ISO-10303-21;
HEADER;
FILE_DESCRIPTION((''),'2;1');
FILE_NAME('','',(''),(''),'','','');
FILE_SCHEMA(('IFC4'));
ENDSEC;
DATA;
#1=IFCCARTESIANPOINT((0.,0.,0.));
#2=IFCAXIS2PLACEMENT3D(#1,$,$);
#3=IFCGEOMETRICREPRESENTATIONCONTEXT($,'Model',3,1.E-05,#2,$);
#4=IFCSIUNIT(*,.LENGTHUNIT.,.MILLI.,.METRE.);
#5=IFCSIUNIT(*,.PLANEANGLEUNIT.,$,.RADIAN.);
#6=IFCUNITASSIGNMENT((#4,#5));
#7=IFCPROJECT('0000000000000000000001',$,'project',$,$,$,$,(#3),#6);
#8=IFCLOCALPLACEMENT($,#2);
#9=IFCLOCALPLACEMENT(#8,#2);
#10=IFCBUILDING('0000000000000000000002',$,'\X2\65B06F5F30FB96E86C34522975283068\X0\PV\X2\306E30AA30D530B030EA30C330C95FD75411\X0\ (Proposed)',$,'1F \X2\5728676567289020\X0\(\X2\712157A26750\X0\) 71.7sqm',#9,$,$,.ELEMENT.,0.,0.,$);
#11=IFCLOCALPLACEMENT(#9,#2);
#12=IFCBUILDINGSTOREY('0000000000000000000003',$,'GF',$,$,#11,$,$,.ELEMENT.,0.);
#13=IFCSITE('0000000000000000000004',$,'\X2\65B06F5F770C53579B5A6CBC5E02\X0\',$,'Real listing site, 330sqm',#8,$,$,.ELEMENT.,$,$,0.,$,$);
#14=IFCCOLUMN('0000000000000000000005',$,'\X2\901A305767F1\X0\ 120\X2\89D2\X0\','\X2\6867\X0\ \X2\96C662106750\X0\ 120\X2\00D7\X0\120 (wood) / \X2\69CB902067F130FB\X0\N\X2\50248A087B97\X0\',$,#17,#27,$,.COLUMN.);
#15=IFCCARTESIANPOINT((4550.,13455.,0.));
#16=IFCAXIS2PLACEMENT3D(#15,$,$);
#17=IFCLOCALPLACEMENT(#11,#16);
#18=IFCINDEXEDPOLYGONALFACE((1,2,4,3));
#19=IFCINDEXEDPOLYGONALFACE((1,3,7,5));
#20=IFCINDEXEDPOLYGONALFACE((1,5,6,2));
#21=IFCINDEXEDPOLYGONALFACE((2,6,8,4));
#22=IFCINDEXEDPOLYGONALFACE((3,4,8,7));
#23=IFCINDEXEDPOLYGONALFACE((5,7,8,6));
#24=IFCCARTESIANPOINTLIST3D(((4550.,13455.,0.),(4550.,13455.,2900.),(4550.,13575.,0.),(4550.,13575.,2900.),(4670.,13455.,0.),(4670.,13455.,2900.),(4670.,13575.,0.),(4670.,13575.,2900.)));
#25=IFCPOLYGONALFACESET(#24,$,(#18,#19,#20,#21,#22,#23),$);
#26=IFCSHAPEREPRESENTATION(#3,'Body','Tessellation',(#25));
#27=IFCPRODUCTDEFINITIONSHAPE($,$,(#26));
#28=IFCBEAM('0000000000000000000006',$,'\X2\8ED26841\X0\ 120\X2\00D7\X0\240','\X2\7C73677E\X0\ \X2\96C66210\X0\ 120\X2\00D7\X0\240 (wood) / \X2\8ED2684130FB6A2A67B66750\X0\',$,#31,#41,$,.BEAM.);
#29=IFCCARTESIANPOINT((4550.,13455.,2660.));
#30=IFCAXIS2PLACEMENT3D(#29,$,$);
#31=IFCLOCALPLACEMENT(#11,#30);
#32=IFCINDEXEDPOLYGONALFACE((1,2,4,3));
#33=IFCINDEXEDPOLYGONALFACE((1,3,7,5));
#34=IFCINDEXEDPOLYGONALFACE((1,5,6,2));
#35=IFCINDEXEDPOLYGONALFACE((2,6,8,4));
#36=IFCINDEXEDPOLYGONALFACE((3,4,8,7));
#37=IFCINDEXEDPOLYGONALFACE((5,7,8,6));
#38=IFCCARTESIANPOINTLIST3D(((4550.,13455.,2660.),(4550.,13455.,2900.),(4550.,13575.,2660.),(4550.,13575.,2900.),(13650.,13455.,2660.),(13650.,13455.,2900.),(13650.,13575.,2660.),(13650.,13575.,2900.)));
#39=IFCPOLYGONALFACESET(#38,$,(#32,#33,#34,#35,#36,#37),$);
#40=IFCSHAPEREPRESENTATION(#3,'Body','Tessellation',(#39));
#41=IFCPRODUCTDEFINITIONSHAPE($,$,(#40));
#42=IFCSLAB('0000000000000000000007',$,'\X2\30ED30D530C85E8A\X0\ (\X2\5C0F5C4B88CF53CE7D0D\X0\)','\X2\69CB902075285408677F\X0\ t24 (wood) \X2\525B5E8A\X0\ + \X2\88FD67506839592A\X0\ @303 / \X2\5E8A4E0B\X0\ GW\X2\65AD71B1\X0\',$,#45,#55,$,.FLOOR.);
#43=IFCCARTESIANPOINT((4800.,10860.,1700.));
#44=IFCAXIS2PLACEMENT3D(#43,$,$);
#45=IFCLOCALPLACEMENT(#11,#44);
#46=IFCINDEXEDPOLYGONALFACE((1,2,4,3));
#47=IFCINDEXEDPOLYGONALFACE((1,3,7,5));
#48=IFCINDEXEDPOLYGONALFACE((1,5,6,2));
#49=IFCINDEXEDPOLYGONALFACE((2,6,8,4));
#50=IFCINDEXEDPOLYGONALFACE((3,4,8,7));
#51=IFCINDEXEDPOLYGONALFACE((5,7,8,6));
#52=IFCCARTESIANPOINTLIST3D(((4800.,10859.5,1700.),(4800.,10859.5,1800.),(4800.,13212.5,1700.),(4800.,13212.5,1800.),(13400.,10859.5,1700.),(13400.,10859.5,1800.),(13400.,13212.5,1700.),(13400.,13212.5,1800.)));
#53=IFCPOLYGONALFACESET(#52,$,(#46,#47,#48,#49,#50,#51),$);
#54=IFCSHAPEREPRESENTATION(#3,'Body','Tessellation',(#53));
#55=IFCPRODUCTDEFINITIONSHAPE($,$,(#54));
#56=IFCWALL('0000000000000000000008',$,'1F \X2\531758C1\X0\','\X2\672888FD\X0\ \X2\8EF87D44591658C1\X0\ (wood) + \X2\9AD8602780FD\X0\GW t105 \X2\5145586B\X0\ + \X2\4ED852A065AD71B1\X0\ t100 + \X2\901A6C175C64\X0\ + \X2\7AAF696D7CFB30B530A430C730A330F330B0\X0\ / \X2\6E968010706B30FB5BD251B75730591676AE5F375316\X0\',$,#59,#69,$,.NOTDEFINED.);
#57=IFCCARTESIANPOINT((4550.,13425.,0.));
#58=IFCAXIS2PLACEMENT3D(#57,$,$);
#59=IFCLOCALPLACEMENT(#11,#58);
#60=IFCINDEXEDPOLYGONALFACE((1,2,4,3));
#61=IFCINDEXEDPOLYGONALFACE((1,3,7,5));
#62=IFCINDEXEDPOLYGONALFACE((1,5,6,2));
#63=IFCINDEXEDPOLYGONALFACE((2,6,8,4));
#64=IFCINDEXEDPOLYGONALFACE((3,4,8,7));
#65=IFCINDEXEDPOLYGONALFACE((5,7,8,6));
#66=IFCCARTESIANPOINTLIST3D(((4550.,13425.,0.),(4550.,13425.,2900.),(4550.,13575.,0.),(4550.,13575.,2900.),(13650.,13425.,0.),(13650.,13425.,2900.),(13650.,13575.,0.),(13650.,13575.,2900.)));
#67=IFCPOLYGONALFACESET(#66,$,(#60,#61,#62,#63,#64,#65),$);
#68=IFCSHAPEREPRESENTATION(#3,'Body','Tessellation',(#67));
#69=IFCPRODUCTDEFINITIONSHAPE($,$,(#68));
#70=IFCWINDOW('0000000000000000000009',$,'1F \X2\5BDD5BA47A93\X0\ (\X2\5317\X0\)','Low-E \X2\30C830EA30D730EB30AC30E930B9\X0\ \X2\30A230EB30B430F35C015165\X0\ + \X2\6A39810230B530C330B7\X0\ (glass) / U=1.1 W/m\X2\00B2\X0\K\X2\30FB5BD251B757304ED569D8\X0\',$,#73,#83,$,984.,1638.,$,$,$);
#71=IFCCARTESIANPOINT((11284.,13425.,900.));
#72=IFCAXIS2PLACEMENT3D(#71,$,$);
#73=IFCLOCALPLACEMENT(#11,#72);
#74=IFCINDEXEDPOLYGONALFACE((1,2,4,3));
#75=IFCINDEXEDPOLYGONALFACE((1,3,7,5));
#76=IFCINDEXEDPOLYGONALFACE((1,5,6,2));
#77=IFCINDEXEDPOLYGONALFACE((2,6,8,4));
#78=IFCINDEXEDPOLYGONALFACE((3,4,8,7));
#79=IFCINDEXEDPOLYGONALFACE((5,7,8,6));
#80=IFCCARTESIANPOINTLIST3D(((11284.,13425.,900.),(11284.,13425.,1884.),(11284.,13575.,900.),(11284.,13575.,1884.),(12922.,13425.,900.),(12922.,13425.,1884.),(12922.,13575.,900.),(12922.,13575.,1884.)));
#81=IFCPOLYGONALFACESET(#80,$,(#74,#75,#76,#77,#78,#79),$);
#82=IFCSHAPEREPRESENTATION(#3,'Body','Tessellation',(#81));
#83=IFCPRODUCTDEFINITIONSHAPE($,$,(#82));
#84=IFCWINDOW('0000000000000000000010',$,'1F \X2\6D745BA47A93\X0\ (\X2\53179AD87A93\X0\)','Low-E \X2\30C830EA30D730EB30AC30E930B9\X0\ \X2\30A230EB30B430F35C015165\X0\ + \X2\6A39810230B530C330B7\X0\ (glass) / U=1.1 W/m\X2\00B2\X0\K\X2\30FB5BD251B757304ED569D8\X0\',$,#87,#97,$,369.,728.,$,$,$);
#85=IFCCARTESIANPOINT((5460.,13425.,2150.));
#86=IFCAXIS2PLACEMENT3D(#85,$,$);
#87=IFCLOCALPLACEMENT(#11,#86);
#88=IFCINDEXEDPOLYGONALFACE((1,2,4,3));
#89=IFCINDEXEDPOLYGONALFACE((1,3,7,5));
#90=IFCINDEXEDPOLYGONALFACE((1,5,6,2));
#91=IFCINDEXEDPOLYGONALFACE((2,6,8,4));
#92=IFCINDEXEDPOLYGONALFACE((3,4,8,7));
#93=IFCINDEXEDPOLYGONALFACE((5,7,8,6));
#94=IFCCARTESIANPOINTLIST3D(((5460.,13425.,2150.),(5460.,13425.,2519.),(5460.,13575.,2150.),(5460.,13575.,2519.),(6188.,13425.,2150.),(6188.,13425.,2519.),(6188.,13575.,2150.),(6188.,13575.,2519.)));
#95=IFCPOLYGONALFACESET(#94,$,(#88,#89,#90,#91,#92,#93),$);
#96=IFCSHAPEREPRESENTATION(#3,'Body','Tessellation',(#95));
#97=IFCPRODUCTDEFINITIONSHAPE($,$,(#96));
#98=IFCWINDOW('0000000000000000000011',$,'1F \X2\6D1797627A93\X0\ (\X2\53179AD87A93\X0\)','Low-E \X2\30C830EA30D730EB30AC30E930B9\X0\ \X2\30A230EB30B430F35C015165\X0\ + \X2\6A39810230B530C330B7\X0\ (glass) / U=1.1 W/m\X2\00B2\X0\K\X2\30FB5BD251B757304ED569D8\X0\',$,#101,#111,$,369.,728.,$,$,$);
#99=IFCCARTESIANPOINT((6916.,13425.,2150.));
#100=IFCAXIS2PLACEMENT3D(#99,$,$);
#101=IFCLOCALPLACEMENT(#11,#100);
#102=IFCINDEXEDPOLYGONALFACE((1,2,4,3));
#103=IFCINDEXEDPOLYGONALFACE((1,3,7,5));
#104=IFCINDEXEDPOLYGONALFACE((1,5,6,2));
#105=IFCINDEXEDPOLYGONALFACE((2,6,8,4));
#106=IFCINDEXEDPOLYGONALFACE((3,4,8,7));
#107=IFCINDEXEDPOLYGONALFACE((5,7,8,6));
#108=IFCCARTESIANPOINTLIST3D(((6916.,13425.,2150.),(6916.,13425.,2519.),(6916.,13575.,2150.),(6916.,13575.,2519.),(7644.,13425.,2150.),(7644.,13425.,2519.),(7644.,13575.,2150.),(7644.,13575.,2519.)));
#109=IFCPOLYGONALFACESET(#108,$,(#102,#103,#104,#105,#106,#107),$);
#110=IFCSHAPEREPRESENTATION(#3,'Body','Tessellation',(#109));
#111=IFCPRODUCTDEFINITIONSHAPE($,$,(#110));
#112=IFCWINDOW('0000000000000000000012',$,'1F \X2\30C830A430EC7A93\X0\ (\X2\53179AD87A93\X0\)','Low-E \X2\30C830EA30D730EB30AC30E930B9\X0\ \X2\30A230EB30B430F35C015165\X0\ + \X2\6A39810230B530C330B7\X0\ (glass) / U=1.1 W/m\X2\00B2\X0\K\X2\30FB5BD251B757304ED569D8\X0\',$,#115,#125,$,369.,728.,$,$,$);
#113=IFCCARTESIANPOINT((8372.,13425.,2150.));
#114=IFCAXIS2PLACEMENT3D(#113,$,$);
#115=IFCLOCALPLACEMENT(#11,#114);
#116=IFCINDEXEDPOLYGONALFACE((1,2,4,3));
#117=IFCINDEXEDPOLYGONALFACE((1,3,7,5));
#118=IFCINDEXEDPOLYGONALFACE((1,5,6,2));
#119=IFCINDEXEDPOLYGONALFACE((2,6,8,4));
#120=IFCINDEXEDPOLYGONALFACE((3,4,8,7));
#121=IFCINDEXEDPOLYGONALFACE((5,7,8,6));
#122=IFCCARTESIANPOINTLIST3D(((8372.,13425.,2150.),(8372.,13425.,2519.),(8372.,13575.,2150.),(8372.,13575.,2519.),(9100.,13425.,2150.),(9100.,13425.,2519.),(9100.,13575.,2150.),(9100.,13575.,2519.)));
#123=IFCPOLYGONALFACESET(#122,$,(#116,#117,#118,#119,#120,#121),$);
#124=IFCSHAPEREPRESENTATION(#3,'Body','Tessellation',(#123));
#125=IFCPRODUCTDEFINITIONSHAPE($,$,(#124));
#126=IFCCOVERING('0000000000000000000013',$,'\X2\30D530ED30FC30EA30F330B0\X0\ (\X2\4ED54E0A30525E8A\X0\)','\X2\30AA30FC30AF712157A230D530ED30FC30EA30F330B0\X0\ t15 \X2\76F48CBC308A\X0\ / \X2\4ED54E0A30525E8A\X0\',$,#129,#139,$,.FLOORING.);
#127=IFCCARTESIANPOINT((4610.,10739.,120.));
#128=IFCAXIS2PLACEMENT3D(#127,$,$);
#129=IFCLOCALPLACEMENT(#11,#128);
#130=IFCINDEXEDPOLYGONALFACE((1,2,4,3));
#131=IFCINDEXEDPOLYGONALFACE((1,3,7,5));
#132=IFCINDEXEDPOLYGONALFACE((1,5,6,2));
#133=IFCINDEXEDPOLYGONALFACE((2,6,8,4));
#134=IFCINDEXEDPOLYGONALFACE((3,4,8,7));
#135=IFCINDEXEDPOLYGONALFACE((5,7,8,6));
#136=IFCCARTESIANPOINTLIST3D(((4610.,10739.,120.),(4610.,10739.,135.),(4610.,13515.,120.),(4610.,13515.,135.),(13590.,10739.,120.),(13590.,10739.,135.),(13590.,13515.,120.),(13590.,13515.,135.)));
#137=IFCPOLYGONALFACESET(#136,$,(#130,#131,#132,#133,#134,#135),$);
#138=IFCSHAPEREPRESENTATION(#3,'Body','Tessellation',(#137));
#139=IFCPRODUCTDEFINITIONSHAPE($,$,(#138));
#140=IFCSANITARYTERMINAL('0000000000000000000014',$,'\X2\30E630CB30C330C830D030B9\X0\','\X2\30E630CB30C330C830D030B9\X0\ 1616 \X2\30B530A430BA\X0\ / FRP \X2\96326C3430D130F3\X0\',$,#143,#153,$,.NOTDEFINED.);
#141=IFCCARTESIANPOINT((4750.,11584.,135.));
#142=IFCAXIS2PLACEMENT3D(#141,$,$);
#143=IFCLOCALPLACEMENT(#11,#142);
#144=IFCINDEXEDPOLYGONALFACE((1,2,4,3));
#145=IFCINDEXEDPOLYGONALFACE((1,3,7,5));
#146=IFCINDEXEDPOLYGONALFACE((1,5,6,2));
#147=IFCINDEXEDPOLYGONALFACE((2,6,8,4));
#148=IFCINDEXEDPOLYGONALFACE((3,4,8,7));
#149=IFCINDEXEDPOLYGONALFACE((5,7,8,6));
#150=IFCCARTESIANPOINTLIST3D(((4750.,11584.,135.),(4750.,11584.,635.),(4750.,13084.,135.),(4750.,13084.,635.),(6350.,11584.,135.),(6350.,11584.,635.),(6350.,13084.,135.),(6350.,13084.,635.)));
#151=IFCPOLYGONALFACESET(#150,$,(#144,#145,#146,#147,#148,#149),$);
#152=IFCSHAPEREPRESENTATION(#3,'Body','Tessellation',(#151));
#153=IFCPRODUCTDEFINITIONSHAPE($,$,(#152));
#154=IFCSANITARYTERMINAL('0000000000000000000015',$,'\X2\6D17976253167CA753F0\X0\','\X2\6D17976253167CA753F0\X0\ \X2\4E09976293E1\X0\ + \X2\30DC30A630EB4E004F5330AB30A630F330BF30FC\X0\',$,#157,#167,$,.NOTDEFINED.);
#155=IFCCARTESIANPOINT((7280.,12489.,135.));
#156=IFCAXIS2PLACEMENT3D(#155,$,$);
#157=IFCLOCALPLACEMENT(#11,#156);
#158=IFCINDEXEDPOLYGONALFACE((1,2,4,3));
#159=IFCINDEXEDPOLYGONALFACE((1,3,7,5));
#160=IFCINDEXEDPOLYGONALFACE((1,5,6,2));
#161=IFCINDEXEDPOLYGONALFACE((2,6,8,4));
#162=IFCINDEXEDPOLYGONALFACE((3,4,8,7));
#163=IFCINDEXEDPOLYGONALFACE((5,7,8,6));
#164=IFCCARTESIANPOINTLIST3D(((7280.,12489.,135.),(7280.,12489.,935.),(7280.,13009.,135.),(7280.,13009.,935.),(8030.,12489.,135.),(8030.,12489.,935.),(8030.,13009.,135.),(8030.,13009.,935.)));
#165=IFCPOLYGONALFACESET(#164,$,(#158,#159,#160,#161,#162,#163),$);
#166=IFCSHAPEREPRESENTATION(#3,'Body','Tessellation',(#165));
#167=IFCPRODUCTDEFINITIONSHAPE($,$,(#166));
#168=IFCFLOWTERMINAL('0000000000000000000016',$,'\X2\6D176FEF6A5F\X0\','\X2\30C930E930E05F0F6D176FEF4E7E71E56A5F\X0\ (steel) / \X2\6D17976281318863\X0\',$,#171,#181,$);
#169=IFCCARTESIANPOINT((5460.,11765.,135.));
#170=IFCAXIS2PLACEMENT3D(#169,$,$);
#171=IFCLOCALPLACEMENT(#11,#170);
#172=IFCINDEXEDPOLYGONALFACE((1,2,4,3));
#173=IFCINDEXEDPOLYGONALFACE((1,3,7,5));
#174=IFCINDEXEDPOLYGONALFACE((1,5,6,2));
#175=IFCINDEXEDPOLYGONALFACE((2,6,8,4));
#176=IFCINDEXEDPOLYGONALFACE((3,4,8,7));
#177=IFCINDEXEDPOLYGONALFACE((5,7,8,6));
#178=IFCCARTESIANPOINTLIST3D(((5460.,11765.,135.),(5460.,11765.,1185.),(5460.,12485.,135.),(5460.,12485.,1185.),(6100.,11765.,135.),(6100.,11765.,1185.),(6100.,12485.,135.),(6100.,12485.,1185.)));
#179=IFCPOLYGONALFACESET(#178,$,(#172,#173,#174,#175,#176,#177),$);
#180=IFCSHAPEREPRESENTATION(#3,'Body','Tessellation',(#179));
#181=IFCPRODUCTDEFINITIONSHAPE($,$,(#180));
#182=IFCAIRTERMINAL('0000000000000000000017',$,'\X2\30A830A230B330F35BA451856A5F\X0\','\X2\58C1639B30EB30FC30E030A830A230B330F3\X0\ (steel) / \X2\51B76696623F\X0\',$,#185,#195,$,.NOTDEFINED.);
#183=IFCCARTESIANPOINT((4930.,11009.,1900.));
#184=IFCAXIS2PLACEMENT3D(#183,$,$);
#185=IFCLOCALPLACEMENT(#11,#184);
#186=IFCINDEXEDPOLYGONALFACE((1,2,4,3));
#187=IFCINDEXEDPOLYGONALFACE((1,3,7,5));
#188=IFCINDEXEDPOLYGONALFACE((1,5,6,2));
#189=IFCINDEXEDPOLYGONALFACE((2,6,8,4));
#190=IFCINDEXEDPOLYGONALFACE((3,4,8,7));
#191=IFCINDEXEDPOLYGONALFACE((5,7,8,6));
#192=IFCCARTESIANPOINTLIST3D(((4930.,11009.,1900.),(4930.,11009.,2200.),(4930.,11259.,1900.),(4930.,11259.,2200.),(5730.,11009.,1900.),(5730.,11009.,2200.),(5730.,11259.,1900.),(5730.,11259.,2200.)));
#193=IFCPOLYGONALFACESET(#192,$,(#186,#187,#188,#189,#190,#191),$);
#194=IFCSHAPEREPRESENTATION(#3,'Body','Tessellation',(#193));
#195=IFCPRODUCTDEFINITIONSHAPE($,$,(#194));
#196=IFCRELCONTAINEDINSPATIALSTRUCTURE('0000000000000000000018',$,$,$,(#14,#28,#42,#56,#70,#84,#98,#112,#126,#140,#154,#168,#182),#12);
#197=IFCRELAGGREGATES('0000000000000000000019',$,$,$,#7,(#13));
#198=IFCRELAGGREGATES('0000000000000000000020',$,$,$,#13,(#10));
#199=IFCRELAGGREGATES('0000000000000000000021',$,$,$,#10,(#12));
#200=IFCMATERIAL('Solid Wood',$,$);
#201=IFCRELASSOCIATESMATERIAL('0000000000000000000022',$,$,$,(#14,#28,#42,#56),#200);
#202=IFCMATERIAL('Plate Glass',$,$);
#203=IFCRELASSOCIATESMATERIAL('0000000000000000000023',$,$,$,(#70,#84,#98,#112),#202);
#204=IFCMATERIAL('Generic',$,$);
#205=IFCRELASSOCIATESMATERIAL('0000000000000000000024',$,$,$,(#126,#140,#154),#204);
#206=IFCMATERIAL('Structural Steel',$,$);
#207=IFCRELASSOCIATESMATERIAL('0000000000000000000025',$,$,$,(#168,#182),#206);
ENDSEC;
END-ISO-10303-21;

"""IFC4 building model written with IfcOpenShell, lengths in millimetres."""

from ifc_helpers import new_model, si_unit, frame, frame_2d, origin, place, context, project, spatial, rectangle, extrude, material, element, fill, save


model = new_model("IFC4")

# Units and contexts
model_context = context("Model", 3, precision=1e-05, world=origin())
ifc_project = project(units=[si_unit("LENGTHUNIT", "METRE", prefix="MILLI"), si_unit("PLANEANGLEUNIT", "RADIAN")], contexts=[model_context])

# Site, building, storey
site_placement = place(None, origin())
site = spatial("IfcSite", under=ifc_project, at=site_placement, Name="新潟県南魚沼市", ObjectType="Real listing site, 330sqm", CompositionType="ELEMENT", RefElevation=0.0)
building_placement = place(site_placement, origin())
building = spatial("IfcBuilding", under=site, at=building_placement, Name="新潟・雨水利用とPVのオフグリッド志向 (Proposed)", ObjectType="1F 在来木造(無垢材) 71.7sqm", CompositionType="ELEMENT", ElevationOfRefHeight=0.0, ElevationOfTerrain=0.0)
storey_placement = place(building_placement, origin())
storey = spatial("IfcBuildingStorey", under=building, at=storey_placement, Name="GF", CompositionType="ELEMENT", Elevation=0.0)

# Column
ifc_material_1 = material(Name="Solid Wood")
column_1_placement = place(storey_placement, frame((4550.0, 13455.0, 0.0)))
element("IfcColumn", 1, at=column_1_placement, inside=storey, material=ifc_material_1, Name="通し柱 120角", Description="桧 集成材 120×120 (wood) / 構造柱・N値計算", PredefinedType="COLUMN", context=model_context, shape_type="SweptSolid", body=[
    extrude(rectangle(XDim=120.0, YDim=120.0, at=frame_2d((60.0, 60.0))), frame((4550.0, 13455.0, 0.0)), (0.0, 0.0, 1.0), 2900.0),
])

# Beam
beam_1_placement = place(storey_placement, frame((4550.0, 13455.0, 2660.0)))
element("IfcBeam", 2, at=beam_1_placement, inside=storey, material=ifc_material_1, Name="軒桁 120×240", Description="米松 集成 120×240 (wood) / 軒桁・横架材", PredefinedType="BEAM", context=model_context, shape_type="SweptSolid", body=[
    extrude(rectangle(XDim=9100.0, YDim=120.0, at=frame_2d((4550.0, 60.0))), frame((4550.0, 13455.0, 2660.0)), (0.0, 0.0, 1.0), 240.0),
])

# Slab
slab_placement = place(storey_placement, frame((4800.0, 10860.0, 1700.0)))
element("IfcSlab", 3, at=slab_placement, inside=storey, material=ifc_material_1, Name="ロフト床 (小屋裏収納)", Description="構造用合板 t24 (wood) 剛床 + 製材根太 @303 / 床下 GW断熱", PredefinedType="FLOOR", context=model_context, shape_type="SweptSolid", body=[
    extrude(rectangle(XDim=8600.0, YDim=2353.0, at=frame_2d((4300.0, 1176.0))), frame((4800.0, 10860.0, 1700.0)), (0.0, 0.0, 1.0), 100.0),
])

# Wall, openings, windows
wall_1_placement = place(storey_placement, frame((4550.0, 13425.0, 0.0)))
wall_1 = element("IfcWall", 4, at=wall_1_placement, inside=storey, material=ifc_material_1, Name="1F 北壁", Description="木製 軸組外壁 (wood) + 高性能GW t105 充填 + 付加断熱 t100 + 通気層 + 窯業系サイディング / 準耐火・寒冷地外皮強化", PredefinedType="NOTDEFINED", context=model_context, shape_type="SweptSolid", body=[
    extrude(rectangle(XDim=9100.0, YDim=150.0, at=frame_2d((4550.0, 75.0))), frame((4550.0, 13425.0, 0.0)), (0.0, 0.0, 1.0), 2900.0),
])
opening_1_placement = place(storey_placement, frame((11284.0, 13425.0, 900.0)))
opening_1 = element("IfcOpeningElement", 5, at=opening_1_placement, cuts=wall_1, PredefinedType="NOTDEFINED", context=model_context, shape_type="SweptSolid", body=[
    extrude(rectangle(XDim=1638.0, YDim=150.0, at=frame_2d((819.0, 75.0))), frame((11284.0, 13425.0, 900.0)), (0.0, 0.0, 1.0), 984.0),
])
opening_2_placement = place(storey_placement, frame((5460.0, 13425.0, 2150.0)))
opening_2 = element("IfcOpeningElement", 6, at=opening_2_placement, cuts=wall_1, PredefinedType="NOTDEFINED", context=model_context, shape_type="SweptSolid", body=[
    extrude(rectangle(XDim=728.0, YDim=150.0, at=frame_2d((364.0, 75.0))), frame((5460.0, 13425.0, 2150.0)), (0.0, 0.0, 1.0), 369.0),
])
opening_3_placement = place(storey_placement, frame((6916.0, 13425.0, 2150.0)))
opening_3 = element("IfcOpeningElement", 7, at=opening_3_placement, cuts=wall_1, PredefinedType="NOTDEFINED", context=model_context, shape_type="SweptSolid", body=[
    extrude(rectangle(XDim=728.0, YDim=150.0, at=frame_2d((364.0, 75.0))), frame((6916.0, 13425.0, 2150.0)), (0.0, 0.0, 1.0), 369.0),
])
opening_4_placement = place(storey_placement, frame((8372.0, 13425.0, 2150.0)))
opening_4 = element("IfcOpeningElement", 8, at=opening_4_placement, cuts=wall_1, PredefinedType="NOTDEFINED", context=model_context, shape_type="SweptSolid", body=[
    extrude(rectangle(XDim=728.0, YDim=150.0, at=frame_2d((364.0, 75.0))), frame((8372.0, 13425.0, 2150.0)), (0.0, 0.0, 1.0), 369.0),
])
ifc_material_2 = material(Name="Plate Glass")
window_1_placement = place(storey_placement, frame((11284.0, 13425.0, 900.0)))
window_1 = element("IfcWindow", 9, at=window_1_placement, inside=storey, material=ifc_material_2, Name="1F 寝室窓 (北)", Description="Low-E トリプルガラス アルゴン封入 + 樹脂サッシ (glass) / U=1.1 W/m²K・寒冷地仕様", OverallHeight=984.0, OverallWidth=1638.0, context=model_context, shape_type="SweptSolid", body=[
    extrude(rectangle(XDim=1638.0, YDim=150.0, at=frame_2d((819.0, 75.0))), frame((11284.0, 13425.0, 900.0)), (0.0, 0.0, 1.0), 984.0),
])
fill(opening_1, window_1)
window_2_placement = place(storey_placement, frame((5460.0, 13425.0, 2150.0)))
window_2 = element("IfcWindow", 10, at=window_2_placement, inside=storey, material=ifc_material_2, Name="1F 浴室窓 (北高窓)", Description="Low-E トリプルガラス アルゴン封入 + 樹脂サッシ (glass) / U=1.1 W/m²K・寒冷地仕様", OverallHeight=369.0, OverallWidth=728.0, context=model_context, shape_type="SweptSolid", body=[
    extrude(rectangle(XDim=728.0, YDim=150.0, at=frame_2d((364.0, 75.0))), frame((5460.0, 13425.0, 2150.0)), (0.0, 0.0, 1.0), 369.0),
])
fill(opening_2, window_2)
window_3_placement = place(storey_placement, frame((6916.0, 13425.0, 2150.0)))
window_3 = element("IfcWindow", 11, at=window_3_placement, inside=storey, material=ifc_material_2, Name="1F 洗面窓 (北高窓)", Description="Low-E トリプルガラス アルゴン封入 + 樹脂サッシ (glass) / U=1.1 W/m²K・寒冷地仕様", OverallHeight=369.0, OverallWidth=728.0, context=model_context, shape_type="SweptSolid", body=[
    extrude(rectangle(XDim=728.0, YDim=150.0, at=frame_2d((364.0, 75.0))), frame((6916.0, 13425.0, 2150.0)), (0.0, 0.0, 1.0), 369.0),
])
fill(opening_3, window_3)
window_4_placement = place(storey_placement, frame((8372.0, 13425.0, 2150.0)))
window_4 = element("IfcWindow", 12, at=window_4_placement, inside=storey, material=ifc_material_2, Name="1F トイレ窓 (北高窓)", Description="Low-E トリプルガラス アルゴン封入 + 樹脂サッシ (glass) / U=1.1 W/m²K・寒冷地仕様", OverallHeight=369.0, OverallWidth=728.0, context=model_context, shape_type="SweptSolid", body=[
    extrude(rectangle(XDim=728.0, YDim=150.0, at=frame_2d((364.0, 75.0))), frame((8372.0, 13425.0, 2150.0)), (0.0, 0.0, 1.0), 369.0),
])
fill(opening_4, window_4)

# Covering
ifc_material_3 = material(Name="Generic")
covering_placement = place(storey_placement, frame((4610.0, 10739.0, 120.0)))
element("IfcCovering", 13, at=covering_placement, inside=storey, material=ifc_material_3, Name="フローリング (仕上げ床)", Description="オーク無垢フローリング t15 直貼り / 仕上げ床", PredefinedType="FLOORING", context=model_context, shape_type="SweptSolid", body=[
    extrude(rectangle(XDim=8980.0, YDim=2776.0, at=frame_2d((4490.0, 1388.0))), frame((4610.0, 10739.0, 120.0)), (0.0, 0.0, 1.0), 15.0),
])

# Sanitary terminals
sanitary_terminal_1_placement = place(storey_placement, frame((4750.0, 11584.0, 135.0)))
element("IfcSanitaryTerminal", 14, at=sanitary_terminal_1_placement, inside=storey, material=ifc_material_3, Name="ユニットバス", Description="ユニットバス 1616 サイズ / FRP 防水パン", PredefinedType="NOTDEFINED", context=model_context, shape_type="SweptSolid", body=[
    extrude(rectangle(XDim=1600.0, YDim=1500.0, at=frame_2d((800.0, 750.0))), frame((4750.0, 11584.0, 135.0)), (0.0, 0.0, 1.0), 500.0),
])
sanitary_terminal_2_placement = place(storey_placement, frame((7280.0, 12489.0, 135.0)))
element("IfcSanitaryTerminal", 15, at=sanitary_terminal_2_placement, inside=storey, material=ifc_material_3, Name="洗面化粧台", Description="洗面化粧台 三面鏡 + ボウル一体カウンター", PredefinedType="NOTDEFINED", context=model_context, shape_type="SweptSolid", body=[
    extrude(rectangle(XDim=750.0, YDim=520.0, at=frame_2d((375.0, 260.0))), frame((7280.0, 12489.0, 135.0)), (0.0, 0.0, 1.0), 800.0),
])

# Flow terminal
ifc_material_4 = material(Name="Structural Steel")
flow_terminal_placement = place(storey_placement, frame((5460.0, 11765.0, 135.0)))
element("IfcFlowTerminal", 16, at=flow_terminal_placement, inside=storey, material=ifc_material_4, Name="洗濯機", Description="ドラム式洗濯乾燥機 (steel) / 洗面脱衣", context=model_context, shape_type="SweptSolid", body=[
    extrude(rectangle(XDim=640.0, YDim=720.0, at=frame_2d((320.0, 360.0))), frame((5460.0, 11765.0, 135.0)), (0.0, 0.0, 1.0), 1050.0),
])

# Air terminal
air_terminal_placement = place(storey_placement, frame((4930.0, 11009.0, 1900.0)))
element("IfcAirTerminal", 17, at=air_terminal_placement, inside=storey, material=ifc_material_4, Name="エアコン室内機", Description="壁掛ルームエアコン (steel) / 冷暖房", PredefinedType="NOTDEFINED", context=model_context, shape_type="SweptSolid", body=[
    extrude(rectangle(XDim=800.0, YDim=250.0, at=frame_2d((400.0, 125.0))), frame((4930.0, 11009.0, 1900.0)), (0.0, 0.0, 1.0), 300.0),
])

save(model, "model.ifc")
